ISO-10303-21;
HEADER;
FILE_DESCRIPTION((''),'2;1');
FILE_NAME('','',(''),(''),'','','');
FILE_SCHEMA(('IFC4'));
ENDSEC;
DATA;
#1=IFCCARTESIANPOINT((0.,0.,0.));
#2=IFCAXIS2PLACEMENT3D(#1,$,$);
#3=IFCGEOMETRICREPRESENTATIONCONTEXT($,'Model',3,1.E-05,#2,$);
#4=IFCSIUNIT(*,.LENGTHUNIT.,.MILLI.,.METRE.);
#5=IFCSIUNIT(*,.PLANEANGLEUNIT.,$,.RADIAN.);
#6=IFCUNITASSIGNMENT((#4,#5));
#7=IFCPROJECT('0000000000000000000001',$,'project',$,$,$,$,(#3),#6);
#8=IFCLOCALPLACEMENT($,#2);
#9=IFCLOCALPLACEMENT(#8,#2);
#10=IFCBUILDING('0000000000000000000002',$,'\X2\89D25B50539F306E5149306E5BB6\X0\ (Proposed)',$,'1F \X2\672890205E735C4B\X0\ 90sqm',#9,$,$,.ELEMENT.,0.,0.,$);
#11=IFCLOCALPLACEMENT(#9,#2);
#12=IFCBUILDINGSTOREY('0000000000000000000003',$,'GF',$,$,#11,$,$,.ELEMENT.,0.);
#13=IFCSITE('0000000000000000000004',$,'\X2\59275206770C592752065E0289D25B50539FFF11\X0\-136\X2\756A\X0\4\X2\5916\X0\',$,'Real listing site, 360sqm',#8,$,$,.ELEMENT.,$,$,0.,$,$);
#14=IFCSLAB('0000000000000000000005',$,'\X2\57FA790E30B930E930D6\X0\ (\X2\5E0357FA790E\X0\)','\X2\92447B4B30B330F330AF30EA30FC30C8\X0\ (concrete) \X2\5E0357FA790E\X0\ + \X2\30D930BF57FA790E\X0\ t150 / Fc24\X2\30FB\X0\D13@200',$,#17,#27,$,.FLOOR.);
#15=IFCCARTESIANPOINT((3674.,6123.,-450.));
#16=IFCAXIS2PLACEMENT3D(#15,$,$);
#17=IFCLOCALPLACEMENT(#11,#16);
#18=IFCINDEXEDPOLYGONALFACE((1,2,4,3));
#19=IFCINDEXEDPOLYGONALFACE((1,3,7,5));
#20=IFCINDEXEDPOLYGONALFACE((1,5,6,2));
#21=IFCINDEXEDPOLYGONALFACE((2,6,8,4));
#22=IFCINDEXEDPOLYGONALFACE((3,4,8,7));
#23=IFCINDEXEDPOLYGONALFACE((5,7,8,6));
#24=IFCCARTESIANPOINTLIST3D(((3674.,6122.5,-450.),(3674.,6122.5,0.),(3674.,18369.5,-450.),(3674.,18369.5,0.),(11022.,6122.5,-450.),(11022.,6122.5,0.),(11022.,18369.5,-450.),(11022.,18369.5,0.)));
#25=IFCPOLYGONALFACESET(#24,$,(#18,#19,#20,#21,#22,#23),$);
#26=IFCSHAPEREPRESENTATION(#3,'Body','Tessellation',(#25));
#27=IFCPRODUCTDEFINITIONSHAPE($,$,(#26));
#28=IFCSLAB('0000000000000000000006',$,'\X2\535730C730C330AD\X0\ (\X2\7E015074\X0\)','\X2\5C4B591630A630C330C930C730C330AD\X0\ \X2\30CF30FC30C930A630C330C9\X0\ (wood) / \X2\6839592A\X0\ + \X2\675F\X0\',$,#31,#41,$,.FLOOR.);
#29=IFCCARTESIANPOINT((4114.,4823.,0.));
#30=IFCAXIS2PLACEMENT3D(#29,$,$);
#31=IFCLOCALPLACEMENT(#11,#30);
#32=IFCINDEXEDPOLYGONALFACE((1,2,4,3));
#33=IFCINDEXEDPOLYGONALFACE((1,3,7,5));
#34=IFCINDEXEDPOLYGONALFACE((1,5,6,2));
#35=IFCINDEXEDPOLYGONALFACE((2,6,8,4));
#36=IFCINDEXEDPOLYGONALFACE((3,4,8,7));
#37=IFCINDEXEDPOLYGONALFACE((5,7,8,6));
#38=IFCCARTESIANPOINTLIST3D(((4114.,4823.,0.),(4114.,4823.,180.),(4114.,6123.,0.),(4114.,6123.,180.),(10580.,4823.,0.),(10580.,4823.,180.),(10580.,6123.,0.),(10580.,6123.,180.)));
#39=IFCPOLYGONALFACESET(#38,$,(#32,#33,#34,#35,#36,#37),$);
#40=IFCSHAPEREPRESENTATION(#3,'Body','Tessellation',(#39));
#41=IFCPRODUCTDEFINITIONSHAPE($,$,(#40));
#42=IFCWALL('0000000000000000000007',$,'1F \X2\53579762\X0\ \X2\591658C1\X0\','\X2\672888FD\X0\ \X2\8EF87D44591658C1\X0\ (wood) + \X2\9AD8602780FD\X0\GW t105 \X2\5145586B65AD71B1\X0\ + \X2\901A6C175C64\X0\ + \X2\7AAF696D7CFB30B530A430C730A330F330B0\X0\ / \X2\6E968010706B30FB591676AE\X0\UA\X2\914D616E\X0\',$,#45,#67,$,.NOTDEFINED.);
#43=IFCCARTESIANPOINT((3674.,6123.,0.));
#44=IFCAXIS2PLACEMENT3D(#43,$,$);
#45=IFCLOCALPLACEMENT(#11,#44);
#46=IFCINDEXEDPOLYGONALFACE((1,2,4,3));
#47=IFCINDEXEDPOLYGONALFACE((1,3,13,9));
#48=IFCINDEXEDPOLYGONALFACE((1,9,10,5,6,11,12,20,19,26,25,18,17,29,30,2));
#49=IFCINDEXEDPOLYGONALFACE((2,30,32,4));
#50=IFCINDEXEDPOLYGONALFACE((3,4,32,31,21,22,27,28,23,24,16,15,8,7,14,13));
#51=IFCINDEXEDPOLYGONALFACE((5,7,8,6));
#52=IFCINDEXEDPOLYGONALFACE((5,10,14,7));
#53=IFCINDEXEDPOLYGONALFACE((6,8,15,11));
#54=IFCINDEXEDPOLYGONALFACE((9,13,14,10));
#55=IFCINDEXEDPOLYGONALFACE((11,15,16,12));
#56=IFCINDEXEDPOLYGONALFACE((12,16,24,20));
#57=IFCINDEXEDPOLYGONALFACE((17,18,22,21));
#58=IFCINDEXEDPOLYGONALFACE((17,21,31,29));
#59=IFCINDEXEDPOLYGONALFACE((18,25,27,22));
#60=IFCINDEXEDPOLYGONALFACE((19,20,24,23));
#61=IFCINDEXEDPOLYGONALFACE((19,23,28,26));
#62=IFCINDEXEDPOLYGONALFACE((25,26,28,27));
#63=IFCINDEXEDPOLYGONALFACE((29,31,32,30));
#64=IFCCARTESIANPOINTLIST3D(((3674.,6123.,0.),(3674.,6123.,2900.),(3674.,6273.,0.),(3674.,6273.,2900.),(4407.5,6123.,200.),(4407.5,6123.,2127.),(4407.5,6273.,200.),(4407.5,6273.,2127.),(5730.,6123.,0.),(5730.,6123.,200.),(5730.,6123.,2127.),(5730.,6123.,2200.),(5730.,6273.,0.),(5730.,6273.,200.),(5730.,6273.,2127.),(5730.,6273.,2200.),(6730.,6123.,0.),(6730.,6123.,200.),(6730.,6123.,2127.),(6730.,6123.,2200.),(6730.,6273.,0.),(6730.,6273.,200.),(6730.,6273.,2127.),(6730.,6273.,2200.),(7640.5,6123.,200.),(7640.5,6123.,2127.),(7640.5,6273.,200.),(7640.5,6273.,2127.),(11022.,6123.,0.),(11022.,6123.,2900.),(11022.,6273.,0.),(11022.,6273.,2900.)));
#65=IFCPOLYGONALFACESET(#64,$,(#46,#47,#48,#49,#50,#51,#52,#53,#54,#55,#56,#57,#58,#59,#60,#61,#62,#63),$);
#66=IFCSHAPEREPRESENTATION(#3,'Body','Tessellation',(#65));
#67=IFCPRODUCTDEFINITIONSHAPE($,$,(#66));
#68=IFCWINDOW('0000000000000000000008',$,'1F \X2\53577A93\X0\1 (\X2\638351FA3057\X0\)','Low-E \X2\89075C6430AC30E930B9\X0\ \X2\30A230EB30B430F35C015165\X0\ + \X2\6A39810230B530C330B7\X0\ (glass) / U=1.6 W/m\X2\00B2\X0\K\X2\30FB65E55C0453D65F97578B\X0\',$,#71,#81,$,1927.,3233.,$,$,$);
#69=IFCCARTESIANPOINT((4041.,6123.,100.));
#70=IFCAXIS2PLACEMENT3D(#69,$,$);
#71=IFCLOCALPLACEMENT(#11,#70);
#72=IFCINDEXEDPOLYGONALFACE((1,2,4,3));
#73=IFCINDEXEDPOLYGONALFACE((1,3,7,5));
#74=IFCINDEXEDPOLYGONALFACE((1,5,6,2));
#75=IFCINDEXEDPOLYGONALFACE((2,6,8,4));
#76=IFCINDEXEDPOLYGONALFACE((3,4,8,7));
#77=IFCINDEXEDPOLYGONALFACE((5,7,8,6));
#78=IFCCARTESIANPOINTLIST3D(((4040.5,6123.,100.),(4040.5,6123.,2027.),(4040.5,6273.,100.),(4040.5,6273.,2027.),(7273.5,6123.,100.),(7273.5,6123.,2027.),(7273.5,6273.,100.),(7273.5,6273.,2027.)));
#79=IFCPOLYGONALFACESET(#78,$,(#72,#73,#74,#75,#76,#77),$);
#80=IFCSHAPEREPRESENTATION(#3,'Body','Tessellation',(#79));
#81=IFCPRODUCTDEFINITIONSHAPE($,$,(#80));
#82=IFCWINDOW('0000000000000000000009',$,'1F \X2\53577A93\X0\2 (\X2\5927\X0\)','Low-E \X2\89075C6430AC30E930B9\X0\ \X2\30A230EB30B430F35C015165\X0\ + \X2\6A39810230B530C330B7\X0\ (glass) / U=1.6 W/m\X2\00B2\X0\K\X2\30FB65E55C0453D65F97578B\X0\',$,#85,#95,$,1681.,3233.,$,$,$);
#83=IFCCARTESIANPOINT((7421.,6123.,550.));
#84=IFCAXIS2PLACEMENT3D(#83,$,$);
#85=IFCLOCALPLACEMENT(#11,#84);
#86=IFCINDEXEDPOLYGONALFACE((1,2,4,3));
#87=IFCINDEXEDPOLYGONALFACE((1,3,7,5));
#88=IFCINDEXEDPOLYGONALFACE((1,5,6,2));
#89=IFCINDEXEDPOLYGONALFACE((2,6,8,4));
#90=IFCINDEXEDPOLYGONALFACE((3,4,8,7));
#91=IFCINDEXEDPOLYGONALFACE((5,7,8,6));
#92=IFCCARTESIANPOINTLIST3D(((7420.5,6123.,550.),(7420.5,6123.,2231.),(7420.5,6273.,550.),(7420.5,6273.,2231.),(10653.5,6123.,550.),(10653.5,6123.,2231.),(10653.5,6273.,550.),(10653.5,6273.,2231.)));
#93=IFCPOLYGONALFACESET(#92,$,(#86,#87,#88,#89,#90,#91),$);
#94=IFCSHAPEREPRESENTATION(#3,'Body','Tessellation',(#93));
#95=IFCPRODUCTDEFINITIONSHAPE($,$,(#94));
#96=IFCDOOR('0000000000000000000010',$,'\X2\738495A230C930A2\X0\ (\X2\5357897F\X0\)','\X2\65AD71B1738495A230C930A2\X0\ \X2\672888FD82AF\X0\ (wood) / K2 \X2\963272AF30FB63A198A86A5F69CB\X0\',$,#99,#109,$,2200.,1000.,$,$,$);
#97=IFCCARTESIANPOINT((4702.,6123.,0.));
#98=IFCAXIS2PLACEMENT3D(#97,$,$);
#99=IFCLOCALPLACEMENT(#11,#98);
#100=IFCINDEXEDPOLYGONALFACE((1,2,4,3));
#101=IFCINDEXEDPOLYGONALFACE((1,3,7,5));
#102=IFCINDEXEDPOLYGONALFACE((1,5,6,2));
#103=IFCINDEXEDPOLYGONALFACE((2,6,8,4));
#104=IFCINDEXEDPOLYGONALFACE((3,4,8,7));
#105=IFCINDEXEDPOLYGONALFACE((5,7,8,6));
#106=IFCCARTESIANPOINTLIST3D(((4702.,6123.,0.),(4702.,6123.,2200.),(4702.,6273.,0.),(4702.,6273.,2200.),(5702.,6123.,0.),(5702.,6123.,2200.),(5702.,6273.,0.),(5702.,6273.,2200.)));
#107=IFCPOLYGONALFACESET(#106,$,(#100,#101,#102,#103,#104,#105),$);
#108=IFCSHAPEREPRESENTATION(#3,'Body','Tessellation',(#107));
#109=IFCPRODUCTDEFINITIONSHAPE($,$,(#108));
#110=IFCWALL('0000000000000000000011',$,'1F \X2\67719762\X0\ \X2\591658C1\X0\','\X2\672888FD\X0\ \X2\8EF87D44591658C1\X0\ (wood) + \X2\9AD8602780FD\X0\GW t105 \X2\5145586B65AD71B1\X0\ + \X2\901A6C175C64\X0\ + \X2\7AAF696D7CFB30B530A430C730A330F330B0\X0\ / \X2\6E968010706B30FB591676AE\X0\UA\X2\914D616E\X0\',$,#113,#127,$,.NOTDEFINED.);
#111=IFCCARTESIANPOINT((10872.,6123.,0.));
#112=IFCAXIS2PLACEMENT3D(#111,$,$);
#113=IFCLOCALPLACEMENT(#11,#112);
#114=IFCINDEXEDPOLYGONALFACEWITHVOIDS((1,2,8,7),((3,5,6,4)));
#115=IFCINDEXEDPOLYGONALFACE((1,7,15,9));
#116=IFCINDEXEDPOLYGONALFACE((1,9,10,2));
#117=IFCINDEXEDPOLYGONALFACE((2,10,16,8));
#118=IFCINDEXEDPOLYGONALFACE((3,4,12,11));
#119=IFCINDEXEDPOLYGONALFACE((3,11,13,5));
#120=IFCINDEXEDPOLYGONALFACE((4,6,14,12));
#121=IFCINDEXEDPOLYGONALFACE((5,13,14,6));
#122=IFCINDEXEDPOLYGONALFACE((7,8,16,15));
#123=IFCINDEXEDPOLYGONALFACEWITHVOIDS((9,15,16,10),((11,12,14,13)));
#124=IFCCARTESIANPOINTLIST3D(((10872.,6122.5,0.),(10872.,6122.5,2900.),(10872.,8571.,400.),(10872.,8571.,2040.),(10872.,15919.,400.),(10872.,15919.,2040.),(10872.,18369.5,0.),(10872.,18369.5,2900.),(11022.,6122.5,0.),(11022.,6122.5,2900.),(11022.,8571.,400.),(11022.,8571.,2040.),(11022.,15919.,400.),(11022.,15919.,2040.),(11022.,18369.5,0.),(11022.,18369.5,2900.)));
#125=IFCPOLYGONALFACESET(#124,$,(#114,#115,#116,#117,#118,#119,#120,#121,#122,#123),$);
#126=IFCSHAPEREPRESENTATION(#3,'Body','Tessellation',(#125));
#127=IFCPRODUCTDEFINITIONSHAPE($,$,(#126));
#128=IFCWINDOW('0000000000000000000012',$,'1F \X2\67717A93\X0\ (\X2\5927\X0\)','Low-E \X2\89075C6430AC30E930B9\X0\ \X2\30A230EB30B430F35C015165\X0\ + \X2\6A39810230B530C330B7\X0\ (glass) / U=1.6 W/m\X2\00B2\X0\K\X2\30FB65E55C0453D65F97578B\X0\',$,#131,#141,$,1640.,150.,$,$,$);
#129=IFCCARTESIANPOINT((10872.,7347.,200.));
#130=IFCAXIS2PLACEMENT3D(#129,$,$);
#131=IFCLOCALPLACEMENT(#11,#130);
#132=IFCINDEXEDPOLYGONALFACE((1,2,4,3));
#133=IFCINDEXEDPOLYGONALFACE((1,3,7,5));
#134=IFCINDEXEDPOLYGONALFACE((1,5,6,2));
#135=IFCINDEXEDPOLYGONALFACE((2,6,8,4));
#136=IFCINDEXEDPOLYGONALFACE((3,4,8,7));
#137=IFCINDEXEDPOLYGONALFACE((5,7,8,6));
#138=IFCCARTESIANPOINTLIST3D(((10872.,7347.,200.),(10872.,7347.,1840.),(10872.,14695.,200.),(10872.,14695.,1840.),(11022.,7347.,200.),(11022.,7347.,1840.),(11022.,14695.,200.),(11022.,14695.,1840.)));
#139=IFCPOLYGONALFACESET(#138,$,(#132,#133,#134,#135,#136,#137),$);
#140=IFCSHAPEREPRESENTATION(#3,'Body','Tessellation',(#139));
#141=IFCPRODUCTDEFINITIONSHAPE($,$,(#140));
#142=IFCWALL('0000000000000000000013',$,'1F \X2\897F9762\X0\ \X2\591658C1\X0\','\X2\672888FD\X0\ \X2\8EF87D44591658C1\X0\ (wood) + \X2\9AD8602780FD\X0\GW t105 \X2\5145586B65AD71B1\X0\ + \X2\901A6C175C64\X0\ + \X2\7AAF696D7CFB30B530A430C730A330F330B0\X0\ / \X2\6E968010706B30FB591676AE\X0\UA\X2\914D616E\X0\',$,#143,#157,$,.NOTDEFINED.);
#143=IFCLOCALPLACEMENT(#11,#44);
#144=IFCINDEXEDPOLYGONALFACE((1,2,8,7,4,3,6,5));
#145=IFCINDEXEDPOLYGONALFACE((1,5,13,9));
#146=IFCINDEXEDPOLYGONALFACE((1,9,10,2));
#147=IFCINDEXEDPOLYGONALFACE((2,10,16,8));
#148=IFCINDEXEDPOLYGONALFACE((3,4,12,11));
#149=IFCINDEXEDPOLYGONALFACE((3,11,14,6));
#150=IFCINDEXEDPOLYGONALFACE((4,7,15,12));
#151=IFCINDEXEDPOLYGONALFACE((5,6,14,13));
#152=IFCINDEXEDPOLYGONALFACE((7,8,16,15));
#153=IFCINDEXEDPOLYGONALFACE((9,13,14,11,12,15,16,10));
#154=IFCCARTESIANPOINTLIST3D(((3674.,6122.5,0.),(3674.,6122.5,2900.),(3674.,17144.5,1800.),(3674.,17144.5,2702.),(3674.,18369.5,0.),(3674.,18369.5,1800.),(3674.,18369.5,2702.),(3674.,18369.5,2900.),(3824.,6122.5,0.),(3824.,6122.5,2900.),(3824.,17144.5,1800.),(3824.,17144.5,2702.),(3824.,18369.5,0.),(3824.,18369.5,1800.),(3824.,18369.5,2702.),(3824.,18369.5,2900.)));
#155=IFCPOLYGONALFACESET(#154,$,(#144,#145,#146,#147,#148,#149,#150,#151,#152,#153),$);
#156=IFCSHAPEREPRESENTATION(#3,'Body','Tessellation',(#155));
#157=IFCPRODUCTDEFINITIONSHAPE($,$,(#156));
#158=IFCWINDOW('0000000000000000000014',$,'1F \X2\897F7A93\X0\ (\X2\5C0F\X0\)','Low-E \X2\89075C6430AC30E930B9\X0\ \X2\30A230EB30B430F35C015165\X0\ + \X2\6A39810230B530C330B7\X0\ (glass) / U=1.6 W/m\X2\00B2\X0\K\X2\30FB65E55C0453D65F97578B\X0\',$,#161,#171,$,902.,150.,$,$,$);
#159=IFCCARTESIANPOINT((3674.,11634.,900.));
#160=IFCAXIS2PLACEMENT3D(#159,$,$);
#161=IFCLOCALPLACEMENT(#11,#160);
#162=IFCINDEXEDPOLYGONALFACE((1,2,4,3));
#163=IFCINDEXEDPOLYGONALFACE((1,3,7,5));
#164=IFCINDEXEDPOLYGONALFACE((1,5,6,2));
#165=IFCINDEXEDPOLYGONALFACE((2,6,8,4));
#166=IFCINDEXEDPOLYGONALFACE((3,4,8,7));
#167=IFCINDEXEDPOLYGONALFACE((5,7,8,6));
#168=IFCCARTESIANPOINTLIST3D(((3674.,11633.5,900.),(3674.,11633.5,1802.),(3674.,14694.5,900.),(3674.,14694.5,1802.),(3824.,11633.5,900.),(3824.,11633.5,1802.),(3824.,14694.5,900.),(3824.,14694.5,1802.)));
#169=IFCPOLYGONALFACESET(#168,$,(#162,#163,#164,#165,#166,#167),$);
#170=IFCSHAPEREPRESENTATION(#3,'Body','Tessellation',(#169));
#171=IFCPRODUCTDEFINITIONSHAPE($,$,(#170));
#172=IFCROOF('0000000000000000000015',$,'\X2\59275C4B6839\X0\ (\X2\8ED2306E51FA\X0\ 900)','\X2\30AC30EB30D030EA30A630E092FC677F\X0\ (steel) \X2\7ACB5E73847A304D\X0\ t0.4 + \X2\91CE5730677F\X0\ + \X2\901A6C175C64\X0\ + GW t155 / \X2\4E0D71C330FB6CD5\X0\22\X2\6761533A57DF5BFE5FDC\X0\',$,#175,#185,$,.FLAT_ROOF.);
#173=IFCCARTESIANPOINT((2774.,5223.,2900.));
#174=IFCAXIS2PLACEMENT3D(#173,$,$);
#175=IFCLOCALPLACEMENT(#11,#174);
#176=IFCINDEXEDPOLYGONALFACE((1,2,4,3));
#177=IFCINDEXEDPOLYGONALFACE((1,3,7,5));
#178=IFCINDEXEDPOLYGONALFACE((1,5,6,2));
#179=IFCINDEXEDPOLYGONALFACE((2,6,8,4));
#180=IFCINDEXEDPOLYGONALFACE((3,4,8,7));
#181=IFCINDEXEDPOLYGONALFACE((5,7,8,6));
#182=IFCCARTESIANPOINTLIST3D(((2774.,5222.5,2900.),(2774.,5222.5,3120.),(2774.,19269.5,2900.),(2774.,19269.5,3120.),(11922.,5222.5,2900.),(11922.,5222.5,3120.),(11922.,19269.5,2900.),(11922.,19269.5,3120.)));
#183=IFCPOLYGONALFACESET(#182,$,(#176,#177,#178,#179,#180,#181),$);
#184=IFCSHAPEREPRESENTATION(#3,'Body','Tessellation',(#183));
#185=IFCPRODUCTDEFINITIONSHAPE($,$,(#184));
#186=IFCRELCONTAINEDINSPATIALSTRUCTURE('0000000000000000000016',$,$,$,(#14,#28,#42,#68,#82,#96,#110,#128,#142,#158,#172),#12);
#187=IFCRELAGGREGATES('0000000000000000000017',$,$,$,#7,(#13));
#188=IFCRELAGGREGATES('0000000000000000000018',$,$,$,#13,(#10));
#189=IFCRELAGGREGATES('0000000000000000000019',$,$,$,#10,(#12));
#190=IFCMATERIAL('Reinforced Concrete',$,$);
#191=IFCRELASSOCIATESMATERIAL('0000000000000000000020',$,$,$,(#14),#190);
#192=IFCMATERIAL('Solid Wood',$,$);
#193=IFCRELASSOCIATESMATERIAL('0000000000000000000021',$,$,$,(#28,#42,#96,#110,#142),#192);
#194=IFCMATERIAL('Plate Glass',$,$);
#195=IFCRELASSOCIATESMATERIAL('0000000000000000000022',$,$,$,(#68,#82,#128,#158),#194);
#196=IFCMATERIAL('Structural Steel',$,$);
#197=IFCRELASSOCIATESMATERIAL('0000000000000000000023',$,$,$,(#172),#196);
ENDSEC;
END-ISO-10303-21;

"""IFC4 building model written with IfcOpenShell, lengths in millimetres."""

from ifc_helpers import new_model, si_unit, frame, frame_2d, origin, place, context, project, spatial, rectangle, extrude, material, element, fill, save


model = new_model("IFC4")

# Units and contexts
model_context = context("Model", 3, precision=1e-05, world=origin())
ifc_project = project(units=[si_unit("LENGTHUNIT", "METRE", prefix="MILLI"), si_unit("PLANEANGLEUNIT", "RADIAN")], contexts=[model_context])

# Site, building, storey
site_placement = place(None, origin())
site = spatial("IfcSite", under=ifc_project, at=site_placement, Name="大分県大分市角子原１-136番4外", ObjectType="Real listing site, 360sqm", CompositionType="ELEMENT", RefElevation=0.0)
building_placement = place(site_placement, origin())
building = spatial("IfcBuilding", under=site, at=building_placement, Name="角子原の光の家 (Proposed)", ObjectType="1F 木造平屋 90sqm", CompositionType="ELEMENT", ElevationOfRefHeight=0.0, ElevationOfTerrain=0.0)
storey_placement = place(building_placement, origin())
storey = spatial("IfcBuildingStorey", under=building, at=storey_placement, Name="GF", CompositionType="ELEMENT", Elevation=0.0)

# Slabs
ifc_material_1 = material(Name="Reinforced Concrete")
slab_1_placement = place(storey_placement, frame((3674.0, 6123.0, -450.0)))
element("IfcSlab", 1, at=slab_1_placement, inside=storey, material=ifc_material_1, Name="基礎スラブ (布基礎)", Description="鉄筋コンクリート (concrete) 布基礎 + ベタ基礎 t150 / Fc24・D13@200", PredefinedType="FLOOR", context=model_context, shape_type="SweptSolid", body=[
    extrude(rectangle(XDim=7348.0, YDim=12247.0, at=frame_2d((3674.0, 6123.0))), frame((3674.0, 6123.0, -450.0)), (0.0, 0.0, 1.0), 450.0),
])
ifc_material_2 = material(Name="Solid Wood")
slab_2_placement = place(storey_placement, frame((4114.0, 4823.0, 0.0)))
element("IfcSlab", 2, at=slab_2_placement, inside=storey, material=ifc_material_2, Name="南デッキ (縁側)", Description="屋外ウッドデッキ ハードウッド (wood) / 根太 + 束", PredefinedType="FLOOR", context=model_context, shape_type="SweptSolid", body=[
    extrude(rectangle(XDim=6466.0, YDim=1300.0, at=frame_2d((3233.0, 650.0))), frame((4114.0, 4823.0, 0.0)), (0.0, 0.0, 1.0), 180.0),
])

# Wall, openings, windows, door
wall_1_placement = place(storey_placement, frame((3674.0, 6123.0, 0.0)))
wall_1 = element("IfcWall", 3, at=wall_1_placement, inside=storey, material=ifc_material_2, Name="1F 南面 外壁", Description="木製 軸組外壁 (wood) + 高性能GW t105 充填断熱 + 通気層 + 窯業系サイディング / 準耐火・外皮UA配慮", PredefinedType="NOTDEFINED", context=model_context, shape_type="SweptSolid", body=[
    extrude(rectangle(XDim=7348.0, YDim=150.0, at=frame_2d((3674.0, 75.0))), frame((3674.0, 6123.0, 0.0)), (0.0, 0.0, 1.0), 2900.0),
])
opening_1_placement = place(storey_placement, frame((4041.0, 6123.0, 100.0)))
opening_1 = element("IfcOpeningElement", 4, at=opening_1_placement, cuts=wall_1, PredefinedType="NOTDEFINED", context=model_context, shape_type="SweptSolid", body=[
    extrude(rectangle(XDim=3233.0, YDim=150.0, at=frame_2d((1616.0, 75.0))), frame((4041.0, 6123.0, 100.0)), (0.0, 0.0, 1.0), 1927.0),
])
opening_2_placement = place(storey_placement, frame((7421.0, 6123.0, 550.0)))
opening_2 = element("IfcOpeningElement", 5, at=opening_2_placement, cuts=wall_1, PredefinedType="NOTDEFINED", context=model_context, shape_type="SweptSolid", body=[
    extrude(rectangle(XDim=3233.0, YDim=150.0, at=frame_2d((1616.0, 75.0))), frame((7421.0, 6123.0, 550.0)), (0.0, 0.0, 1.0), 1681.0),
])
opening_3_placement = place(storey_placement, frame((4702.0, 6123.0, 0.0)))
opening_3 = element("IfcOpeningElement", 6, at=opening_3_placement, cuts=wall_1, PredefinedType="NOTDEFINED", context=model_context, shape_type="SweptSolid", body=[
    extrude(rectangle(XDim=1000.0, YDim=150.0, at=frame_2d((500.0, 75.0))), frame((4702.0, 6123.0, 0.0)), (0.0, 0.0, 1.0), 2200.0),
])
ifc_material_3 = material(Name="Plate Glass")
window_1_placement = place(storey_placement, frame((4041.0, 6123.0, 100.0)))
window_1 = element("IfcWindow", 7, at=window_1_placement, inside=storey, material=ifc_material_3, Name="1F 南窓1 (掃出し)", Description="Low-E 複層ガラス アルゴン封入 + 樹脂サッシ (glass) / U=1.6 W/m²K・日射取得型", OverallHeight=1927.0, OverallWidth=3233.0, context=model_context, shape_type="SweptSolid", body=[
    extrude(rectangle(XDim=3233.0, YDim=150.0, at=frame_2d((1616.0, 75.0))), frame((4041.0, 6123.0, 100.0)), (0.0, 0.0, 1.0), 1927.0),
])
fill(opening_1, window_1)
window_2_placement = place(storey_placement, frame((7421.0, 6123.0, 550.0)))
window_2 = element("IfcWindow", 8, at=window_2_placement, inside=storey, material=ifc_material_3, Name="1F 南窓2 (大)", Description="Low-E 複層ガラス アルゴン封入 + 樹脂サッシ (glass) / U=1.6 W/m²K・日射取得型", OverallHeight=1681.0, OverallWidth=3233.0, context=model_context, shape_type="SweptSolid", body=[
    extrude(rectangle(XDim=3233.0, YDim=150.0, at=frame_2d((1616.0, 75.0))), frame((7421.0, 6123.0, 550.0)), (0.0, 0.0, 1.0), 1681.0),
])
fill(opening_2, window_2)
door_placement = place(storey_placement, frame((4702.0, 6123.0, 0.0)))
door = element("IfcDoor", 9, at=door_placement, inside=storey, material=ifc_material_2, Name="玄関ドア (南西)", Description="断熱玄関ドア 木製芯 (wood) / K2 防犯・採風機構", OverallHeight=2200.0, OverallWidth=1000.0, context=model_context, shape_type="SweptSolid", body=[
    extrude(rectangle(XDim=1000.0, YDim=150.0, at=frame_2d((500.0, 75.0))), frame((4702.0, 6123.0, 0.0)), (0.0, 0.0, 1.0), 2200.0),
])
fill(opening_3, door)

# Walls, openings, windows
wall_2_placement = place(storey_placement, frame((10872.0, 6123.0, 0.0)))
wall_2 = element("IfcWall", 10, at=wall_2_placement, inside=storey, material=ifc_material_2, Name="1F 東面 外壁", Description="木製 軸組外壁 (wood) + 高性能GW t105 充填断熱 + 通気層 + 窯業系サイディング / 準耐火・外皮UA配慮", PredefinedType="NOTDEFINED", context=model_context, shape_type="SweptSolid", body=[
    extrude(rectangle(XDim=150.0, YDim=12247.0, at=frame_2d((75.0, 6123.0))), frame((10872.0, 6123.0, 0.0)), (0.0, 0.0, 1.0), 2900.0),
])
opening_4_placement = place(storey_placement, frame((10872.0, 7347.0, 200.0)))
opening_4 = element("IfcOpeningElement", 11, at=opening_4_placement, cuts=wall_2, PredefinedType="NOTDEFINED", context=model_context, shape_type="SweptSolid", body=[
    extrude(rectangle(XDim=150.0, YDim=7348.0, at=frame_2d((75.0, 3674.0))), frame((10872.0, 7347.0, 200.0)), (0.0, 0.0, 1.0), 1640.0),
])
window_3_placement = place(storey_placement, frame((10872.0, 7347.0, 200.0)))
window_3 = element("IfcWindow", 12, at=window_3_placement, inside=storey, material=ifc_material_3, Name="1F 東窓 (大)", Description="Low-E 複層ガラス アルゴン封入 + 樹脂サッシ (glass) / U=1.6 W/m²K・日射取得型", OverallHeight=1640.0, OverallWidth=150.0, context=model_context, shape_type="SweptSolid", body=[
    extrude(rectangle(XDim=150.0, YDim=7348.0, at=frame_2d((75.0, 3674.0))), frame((10872.0, 7347.0, 200.0)), (0.0, 0.0, 1.0), 1640.0),
])
fill(opening_4, window_3)
wall_3_placement = place(storey_placement, frame((3674.0, 6123.0, 0.0)))
wall_3 = element("IfcWall", 13, at=wall_3_placement, inside=storey, material=ifc_material_2, Name="1F 西面 外壁", Description="木製 軸組外壁 (wood) + 高性能GW t105 充填断熱 + 通気層 + 窯業系サイディング / 準耐火・外皮UA配慮", PredefinedType="NOTDEFINED", context=model_context, shape_type="SweptSolid", body=[
    extrude(rectangle(XDim=150.0, YDim=12247.0, at=frame_2d((75.0, 6123.0))), frame((3674.0, 6123.0, 0.0)), (0.0, 0.0, 1.0), 2900.0),
])
opening_5_placement = place(storey_placement, frame((3674.0, 11634.0, 900.0)))
opening_5 = element("IfcOpeningElement", 14, at=opening_5_placement, cuts=wall_3, PredefinedType="NOTDEFINED", context=model_context, shape_type="SweptSolid", body=[
    extrude(rectangle(XDim=150.0, YDim=3061.0, at=frame_2d((75.0, 1530.0))), frame((3674.0, 11634.0, 900.0)), (0.0, 0.0, 1.0), 902.0),
])
window_4_placement = place(storey_placement, frame((3674.0, 11634.0, 900.0)))
window_4 = element("IfcWindow", 15, at=window_4_placement, inside=storey, material=ifc_material_3, Name="1F 西窓 (小)", Description="Low-E 複層ガラス アルゴン封入 + 樹脂サッシ (glass) / U=1.6 W/m²K・日射取得型", OverallHeight=902.0, OverallWidth=150.0, context=model_context, shape_type="SweptSolid", body=[
    extrude(rectangle(XDim=150.0, YDim=3061.0, at=frame_2d((75.0, 1530.0))), frame((3674.0, 11634.0, 900.0)), (0.0, 0.0, 1.0), 902.0),
])
fill(opening_5, window_4)

# Roof
ifc_material_4 = material(Name="Structural Steel")
roof_placement = place(storey_placement, frame((2774.0, 5223.0, 2900.0)))
element("IfcRoof", 16, at=roof_placement, inside=storey, material=ifc_material_4, Name="大屋根 (軒の出 900)", Description="ガルバリウム鋼板 (steel) 立平葺き t0.4 + 野地板 + 通気層 + GW t155 / 不燃・法22条区域対応", PredefinedType="FLAT_ROOF", context=model_context, shape_type="SweptSolid", body=[
    extrude(rectangle(XDim=9148.0, YDim=14047.0, at=frame_2d((4574.0, 7023.0))), frame((2774.0, 5223.0, 2900.0)), (0.0, 0.0, 1.0), 220.0),
])

save(model, "model.ifc")
